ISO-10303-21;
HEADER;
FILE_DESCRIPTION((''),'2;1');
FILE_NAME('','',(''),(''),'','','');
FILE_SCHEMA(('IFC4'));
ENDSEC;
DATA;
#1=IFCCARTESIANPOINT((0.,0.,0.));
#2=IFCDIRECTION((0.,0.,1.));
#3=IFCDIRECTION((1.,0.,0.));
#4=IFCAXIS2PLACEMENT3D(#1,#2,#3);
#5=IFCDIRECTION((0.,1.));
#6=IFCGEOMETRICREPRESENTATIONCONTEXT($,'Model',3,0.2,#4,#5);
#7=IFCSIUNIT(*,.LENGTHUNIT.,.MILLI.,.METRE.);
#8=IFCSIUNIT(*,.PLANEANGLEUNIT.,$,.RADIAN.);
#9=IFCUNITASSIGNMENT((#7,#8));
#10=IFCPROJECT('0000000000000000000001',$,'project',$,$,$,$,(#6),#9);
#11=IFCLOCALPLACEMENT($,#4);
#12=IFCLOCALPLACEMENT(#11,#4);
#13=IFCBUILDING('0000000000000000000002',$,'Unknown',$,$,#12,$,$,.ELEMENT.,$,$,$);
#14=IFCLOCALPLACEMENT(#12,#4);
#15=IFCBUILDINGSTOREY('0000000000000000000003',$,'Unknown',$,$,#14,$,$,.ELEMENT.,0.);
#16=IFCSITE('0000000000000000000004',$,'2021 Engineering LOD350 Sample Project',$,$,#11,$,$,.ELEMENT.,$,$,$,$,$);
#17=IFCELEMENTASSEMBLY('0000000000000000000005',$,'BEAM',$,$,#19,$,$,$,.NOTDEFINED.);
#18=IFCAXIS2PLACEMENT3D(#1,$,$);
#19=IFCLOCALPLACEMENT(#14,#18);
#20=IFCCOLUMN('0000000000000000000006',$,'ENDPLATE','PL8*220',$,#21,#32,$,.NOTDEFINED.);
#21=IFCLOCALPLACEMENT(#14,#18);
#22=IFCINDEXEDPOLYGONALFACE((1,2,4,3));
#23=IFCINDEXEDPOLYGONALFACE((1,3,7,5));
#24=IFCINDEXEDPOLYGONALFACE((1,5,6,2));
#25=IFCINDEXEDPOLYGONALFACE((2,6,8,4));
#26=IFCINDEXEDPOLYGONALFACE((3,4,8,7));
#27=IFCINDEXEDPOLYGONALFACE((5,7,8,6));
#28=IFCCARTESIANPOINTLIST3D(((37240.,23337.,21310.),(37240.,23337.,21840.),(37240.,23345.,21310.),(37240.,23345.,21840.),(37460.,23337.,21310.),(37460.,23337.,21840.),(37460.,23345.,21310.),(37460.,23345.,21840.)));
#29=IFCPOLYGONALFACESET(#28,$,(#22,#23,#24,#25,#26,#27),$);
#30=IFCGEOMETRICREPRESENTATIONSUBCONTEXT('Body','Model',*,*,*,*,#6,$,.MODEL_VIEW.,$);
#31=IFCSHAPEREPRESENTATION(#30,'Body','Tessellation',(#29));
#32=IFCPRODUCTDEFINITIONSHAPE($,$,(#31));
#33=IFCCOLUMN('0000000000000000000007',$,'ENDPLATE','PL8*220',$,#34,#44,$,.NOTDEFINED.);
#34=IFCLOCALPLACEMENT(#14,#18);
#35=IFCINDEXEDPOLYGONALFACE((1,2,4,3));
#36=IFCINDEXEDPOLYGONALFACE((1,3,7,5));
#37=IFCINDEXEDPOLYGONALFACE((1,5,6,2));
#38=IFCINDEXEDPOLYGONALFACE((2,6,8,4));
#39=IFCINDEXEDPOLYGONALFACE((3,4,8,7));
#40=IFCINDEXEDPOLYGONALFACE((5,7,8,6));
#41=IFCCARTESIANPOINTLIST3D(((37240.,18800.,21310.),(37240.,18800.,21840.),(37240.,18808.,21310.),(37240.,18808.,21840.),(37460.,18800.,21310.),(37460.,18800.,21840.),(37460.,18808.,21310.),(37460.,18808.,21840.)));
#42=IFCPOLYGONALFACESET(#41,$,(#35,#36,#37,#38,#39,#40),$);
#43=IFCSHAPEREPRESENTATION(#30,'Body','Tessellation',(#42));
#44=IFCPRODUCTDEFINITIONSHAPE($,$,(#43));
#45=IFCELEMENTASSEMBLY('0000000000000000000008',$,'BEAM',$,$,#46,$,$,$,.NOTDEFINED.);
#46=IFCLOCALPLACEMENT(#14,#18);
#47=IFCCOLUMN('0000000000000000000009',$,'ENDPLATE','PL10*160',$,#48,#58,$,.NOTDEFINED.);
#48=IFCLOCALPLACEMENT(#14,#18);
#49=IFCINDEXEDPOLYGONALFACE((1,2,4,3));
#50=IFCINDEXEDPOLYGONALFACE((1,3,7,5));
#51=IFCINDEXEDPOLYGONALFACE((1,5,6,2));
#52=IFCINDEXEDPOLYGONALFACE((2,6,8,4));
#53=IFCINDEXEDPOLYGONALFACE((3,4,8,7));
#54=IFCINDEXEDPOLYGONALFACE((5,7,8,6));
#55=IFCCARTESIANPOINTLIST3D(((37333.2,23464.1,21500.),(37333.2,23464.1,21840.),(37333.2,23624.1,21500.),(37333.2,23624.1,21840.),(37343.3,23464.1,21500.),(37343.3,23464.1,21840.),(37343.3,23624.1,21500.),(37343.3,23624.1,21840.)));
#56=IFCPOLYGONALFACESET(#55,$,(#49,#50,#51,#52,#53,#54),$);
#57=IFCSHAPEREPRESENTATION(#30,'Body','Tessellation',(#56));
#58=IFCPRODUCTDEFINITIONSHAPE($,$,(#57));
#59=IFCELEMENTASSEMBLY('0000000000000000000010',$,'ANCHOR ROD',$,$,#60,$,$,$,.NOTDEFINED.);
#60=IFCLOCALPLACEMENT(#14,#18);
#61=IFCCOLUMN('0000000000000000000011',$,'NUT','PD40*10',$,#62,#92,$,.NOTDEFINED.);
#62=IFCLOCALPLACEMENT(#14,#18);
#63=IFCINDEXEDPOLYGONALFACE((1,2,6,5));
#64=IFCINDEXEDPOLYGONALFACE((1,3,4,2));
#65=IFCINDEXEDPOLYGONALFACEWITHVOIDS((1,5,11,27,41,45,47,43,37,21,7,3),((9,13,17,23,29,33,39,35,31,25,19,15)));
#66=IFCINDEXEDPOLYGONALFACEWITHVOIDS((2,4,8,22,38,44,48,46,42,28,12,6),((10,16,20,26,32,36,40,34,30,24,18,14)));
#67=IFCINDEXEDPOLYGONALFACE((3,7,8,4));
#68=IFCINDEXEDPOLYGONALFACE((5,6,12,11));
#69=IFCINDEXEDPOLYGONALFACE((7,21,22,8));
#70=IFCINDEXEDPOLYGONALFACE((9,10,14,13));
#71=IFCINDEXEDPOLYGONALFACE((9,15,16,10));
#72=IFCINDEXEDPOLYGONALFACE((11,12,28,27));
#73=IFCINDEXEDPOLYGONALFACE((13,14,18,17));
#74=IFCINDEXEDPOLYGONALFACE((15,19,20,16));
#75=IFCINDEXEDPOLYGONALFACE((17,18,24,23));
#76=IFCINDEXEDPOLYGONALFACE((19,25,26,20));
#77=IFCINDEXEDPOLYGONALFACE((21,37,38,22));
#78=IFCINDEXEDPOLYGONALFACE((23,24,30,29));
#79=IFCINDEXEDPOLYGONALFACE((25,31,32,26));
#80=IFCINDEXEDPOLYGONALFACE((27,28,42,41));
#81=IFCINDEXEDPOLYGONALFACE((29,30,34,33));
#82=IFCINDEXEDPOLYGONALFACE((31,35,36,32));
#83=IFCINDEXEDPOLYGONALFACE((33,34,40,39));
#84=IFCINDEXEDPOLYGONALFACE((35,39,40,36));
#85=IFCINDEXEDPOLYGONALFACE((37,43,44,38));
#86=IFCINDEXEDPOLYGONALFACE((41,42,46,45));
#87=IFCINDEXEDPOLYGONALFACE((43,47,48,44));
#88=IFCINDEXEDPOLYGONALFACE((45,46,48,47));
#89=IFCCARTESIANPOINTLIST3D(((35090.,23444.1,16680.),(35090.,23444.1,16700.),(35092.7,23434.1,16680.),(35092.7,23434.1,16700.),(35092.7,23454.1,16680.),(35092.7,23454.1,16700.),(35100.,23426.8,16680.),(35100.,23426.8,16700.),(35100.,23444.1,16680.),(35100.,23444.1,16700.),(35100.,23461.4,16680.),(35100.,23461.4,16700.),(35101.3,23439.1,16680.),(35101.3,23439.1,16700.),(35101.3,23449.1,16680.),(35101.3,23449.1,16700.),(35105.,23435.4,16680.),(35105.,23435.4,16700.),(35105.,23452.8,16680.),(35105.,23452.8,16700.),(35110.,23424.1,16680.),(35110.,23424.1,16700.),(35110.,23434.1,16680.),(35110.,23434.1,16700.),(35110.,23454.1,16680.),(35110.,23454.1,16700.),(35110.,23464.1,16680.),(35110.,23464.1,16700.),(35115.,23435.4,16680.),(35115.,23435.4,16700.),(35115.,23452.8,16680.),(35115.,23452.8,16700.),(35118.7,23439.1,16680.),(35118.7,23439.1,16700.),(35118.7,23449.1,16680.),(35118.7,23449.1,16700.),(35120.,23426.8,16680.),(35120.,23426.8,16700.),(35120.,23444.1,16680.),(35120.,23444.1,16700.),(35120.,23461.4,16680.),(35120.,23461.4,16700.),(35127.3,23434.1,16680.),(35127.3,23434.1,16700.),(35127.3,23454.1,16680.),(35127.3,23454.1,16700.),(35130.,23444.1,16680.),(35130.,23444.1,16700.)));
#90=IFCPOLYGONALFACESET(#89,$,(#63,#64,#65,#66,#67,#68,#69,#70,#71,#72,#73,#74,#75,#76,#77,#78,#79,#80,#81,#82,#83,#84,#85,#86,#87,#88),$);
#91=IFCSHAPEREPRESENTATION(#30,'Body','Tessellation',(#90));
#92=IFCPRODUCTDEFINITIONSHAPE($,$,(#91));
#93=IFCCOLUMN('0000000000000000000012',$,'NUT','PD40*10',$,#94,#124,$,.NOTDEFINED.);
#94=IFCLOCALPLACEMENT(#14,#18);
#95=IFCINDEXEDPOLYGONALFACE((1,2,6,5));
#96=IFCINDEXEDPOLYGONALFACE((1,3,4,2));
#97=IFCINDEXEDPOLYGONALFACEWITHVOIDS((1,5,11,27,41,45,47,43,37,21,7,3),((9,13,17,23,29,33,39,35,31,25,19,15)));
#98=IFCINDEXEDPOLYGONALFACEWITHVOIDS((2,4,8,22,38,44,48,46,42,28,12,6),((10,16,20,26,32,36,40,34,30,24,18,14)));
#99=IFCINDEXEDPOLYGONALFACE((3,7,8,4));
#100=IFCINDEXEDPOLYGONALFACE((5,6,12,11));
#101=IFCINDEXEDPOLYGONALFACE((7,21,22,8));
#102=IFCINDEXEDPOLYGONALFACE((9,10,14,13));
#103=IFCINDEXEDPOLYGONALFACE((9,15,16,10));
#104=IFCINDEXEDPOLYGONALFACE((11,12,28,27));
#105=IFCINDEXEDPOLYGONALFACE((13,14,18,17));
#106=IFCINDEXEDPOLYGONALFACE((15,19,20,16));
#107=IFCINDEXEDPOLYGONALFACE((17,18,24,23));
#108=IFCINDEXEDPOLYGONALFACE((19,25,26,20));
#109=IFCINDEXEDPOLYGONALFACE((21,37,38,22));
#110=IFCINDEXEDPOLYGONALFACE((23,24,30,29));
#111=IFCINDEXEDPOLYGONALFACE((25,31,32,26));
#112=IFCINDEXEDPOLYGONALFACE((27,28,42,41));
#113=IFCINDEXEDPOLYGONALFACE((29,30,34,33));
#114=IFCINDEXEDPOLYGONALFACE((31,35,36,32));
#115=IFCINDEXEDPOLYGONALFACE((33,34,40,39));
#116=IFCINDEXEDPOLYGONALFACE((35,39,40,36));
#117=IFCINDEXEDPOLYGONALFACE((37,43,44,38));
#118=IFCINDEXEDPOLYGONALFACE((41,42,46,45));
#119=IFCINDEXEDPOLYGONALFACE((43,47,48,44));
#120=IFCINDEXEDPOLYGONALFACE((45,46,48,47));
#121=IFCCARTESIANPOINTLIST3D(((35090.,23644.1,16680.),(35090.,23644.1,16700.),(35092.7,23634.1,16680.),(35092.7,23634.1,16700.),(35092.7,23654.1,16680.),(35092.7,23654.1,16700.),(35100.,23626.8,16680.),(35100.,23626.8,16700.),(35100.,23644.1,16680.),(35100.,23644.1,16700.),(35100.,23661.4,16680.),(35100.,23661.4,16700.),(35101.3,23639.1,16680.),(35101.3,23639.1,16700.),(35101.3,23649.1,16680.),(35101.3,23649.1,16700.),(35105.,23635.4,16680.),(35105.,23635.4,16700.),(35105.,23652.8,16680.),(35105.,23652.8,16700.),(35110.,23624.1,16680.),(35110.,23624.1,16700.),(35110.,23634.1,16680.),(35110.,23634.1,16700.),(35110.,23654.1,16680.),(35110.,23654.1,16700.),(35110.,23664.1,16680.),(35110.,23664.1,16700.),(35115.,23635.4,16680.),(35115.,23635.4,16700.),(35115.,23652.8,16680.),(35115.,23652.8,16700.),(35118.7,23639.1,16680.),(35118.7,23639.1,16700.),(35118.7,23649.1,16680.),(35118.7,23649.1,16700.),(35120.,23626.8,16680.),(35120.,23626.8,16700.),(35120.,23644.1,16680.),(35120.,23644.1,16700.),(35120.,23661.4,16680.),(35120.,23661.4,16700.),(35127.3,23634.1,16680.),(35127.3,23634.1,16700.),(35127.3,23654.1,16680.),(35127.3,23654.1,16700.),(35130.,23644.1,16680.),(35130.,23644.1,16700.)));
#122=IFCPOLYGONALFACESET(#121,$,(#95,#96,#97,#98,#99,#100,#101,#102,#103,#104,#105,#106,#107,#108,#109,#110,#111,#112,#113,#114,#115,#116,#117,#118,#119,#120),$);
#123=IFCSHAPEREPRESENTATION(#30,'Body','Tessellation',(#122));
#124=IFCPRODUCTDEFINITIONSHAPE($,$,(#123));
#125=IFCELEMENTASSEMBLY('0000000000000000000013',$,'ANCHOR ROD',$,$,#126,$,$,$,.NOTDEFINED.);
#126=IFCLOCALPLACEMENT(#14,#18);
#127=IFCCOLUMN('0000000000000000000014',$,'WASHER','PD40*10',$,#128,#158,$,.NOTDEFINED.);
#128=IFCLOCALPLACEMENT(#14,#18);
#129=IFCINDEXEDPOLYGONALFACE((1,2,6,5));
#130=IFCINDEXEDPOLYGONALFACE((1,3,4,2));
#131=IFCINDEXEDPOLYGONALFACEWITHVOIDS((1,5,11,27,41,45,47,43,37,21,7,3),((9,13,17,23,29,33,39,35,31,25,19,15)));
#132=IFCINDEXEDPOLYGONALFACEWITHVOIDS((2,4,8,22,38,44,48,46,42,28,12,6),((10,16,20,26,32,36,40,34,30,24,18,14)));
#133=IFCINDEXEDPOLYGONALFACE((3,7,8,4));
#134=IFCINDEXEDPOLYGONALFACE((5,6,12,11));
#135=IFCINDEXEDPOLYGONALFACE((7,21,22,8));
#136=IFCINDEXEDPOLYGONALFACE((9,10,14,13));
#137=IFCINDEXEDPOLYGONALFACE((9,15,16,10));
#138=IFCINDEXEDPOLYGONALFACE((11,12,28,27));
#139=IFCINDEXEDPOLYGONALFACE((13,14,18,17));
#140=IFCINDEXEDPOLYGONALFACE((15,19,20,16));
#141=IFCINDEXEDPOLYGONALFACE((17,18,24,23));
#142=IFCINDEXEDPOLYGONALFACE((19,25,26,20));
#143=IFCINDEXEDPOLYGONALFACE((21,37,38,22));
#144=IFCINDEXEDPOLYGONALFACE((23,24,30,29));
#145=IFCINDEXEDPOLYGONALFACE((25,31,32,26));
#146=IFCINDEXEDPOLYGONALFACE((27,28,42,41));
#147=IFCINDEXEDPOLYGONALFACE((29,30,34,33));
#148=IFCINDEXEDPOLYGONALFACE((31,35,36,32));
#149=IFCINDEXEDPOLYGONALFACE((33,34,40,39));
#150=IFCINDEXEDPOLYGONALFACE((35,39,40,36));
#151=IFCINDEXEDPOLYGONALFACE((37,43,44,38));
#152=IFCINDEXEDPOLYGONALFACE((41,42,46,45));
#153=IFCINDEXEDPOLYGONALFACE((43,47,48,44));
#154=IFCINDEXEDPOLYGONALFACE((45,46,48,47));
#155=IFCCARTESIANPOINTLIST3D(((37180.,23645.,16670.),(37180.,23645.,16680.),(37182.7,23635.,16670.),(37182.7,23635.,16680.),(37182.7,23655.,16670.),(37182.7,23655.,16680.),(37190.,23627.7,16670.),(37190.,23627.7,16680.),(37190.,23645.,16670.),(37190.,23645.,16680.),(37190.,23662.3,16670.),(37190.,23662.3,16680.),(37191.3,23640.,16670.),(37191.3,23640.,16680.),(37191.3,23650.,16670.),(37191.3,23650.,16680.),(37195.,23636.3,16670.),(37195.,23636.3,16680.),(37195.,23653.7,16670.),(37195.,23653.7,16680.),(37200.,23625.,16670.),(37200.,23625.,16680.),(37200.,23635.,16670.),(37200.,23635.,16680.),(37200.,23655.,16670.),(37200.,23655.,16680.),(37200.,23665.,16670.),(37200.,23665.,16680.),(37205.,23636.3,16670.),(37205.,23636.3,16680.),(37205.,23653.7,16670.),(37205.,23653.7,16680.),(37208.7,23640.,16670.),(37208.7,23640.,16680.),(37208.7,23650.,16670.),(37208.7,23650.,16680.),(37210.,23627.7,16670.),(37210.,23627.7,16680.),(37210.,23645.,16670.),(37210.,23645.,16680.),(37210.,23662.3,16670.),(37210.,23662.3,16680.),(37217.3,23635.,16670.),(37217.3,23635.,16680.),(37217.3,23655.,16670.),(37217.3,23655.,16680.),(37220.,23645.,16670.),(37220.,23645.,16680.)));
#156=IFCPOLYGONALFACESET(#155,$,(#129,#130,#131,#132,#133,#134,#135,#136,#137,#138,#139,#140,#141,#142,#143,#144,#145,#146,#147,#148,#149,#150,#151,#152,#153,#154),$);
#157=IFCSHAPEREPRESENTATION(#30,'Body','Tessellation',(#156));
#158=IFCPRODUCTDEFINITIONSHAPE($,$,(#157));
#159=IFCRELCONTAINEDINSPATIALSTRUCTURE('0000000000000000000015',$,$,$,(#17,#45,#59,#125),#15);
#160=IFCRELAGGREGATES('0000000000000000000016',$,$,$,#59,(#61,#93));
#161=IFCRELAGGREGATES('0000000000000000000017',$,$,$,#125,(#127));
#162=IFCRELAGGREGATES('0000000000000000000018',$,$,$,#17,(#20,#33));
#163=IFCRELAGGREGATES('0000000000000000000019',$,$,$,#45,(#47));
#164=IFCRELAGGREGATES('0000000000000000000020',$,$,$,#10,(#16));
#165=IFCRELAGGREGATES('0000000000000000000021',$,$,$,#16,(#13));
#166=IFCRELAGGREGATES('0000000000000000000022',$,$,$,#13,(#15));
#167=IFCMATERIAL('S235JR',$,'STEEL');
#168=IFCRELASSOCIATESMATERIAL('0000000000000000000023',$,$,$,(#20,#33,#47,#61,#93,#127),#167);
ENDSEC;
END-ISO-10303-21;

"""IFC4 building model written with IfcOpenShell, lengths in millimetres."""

from ifc_helpers import new_model, si_unit, direction, frame, origin_with_axes, place, context, subcontext, project, spatial, line, indexed_curve, outline, extrude, material, element, aggregate, save


model = new_model("IFC4")

# Units and contexts
model_context = context("Model", 3, precision=0.2, world=origin_with_axes(), true_north=direction((0.0, 1.0)))
body_context = subcontext(model_context, "Body", "Model", "MODEL_VIEW")
ifc_project = project(units=[si_unit("LENGTHUNIT", "METRE", prefix="MILLI"), si_unit("PLANEANGLEUNIT", "RADIAN")], contexts=[model_context])

# Site, building, storey
site_placement = place(None, origin_with_axes())
site = spatial("IfcSite", under=ifc_project, at=site_placement, Name="2021 Engineering LOD350 Sample Project", CompositionType="ELEMENT")
building_placement = place(site_placement, origin_with_axes())
building = spatial("IfcBuilding", under=site, at=building_placement, Name="Unknown", CompositionType="ELEMENT")
storey_placement = place(building_placement, origin_with_axes())
storey = spatial("IfcBuildingStorey", under=building, at=storey_placement, Name="Unknown", CompositionType="ELEMENT", Elevation=0.0)

# Shared definitions
ifc_material_1 = material(Name="S235JR", Category="STEEL")

# Element assembly, columns
assembly_1_placement = place(storey_placement, frame((37350.0, 18600.0, 21575.0), z_axis=(1.0, 0.0, 0.0), x_axis=(0.0, 1.0, 0.0)))
assembly_1 = element("IfcElementAssembly", 1, at=assembly_1_placement, inside=storey, Name="BEAM", PredefinedType="NOTDEFINED")
column_1_placement = place(assembly_1_placement, frame((4741.0, -265.0, 0.0), z_axis=(-1.0, 0.0, 0.0), x_axis=(0.0, 1.0, 0.0)))
column_1 = element("IfcColumn", 2, at=column_1_placement, material=ifc_material_1, Name="ENDPLATE", Description="PL8*220", PredefinedType="NOTDEFINED", context=body_context, shape_type="SolidModel", body=[
    extrude(outline(indexed_curve([(-4.0, -110.0), (4.0, -110.0), (4.0, 110.0), (-4.0, 110.0)], segments=[line(1, 2, 3, 4, 1)])), frame((0.0, 0.0, 0.0), z_axis=(-1.0, 0.0, 0.0), x_axis=(0.0, 0.0, 1.0)), (0.0, 0.0, -1.0), 530.0),
])
column_2_placement = place(assembly_1_placement, frame((204.0, -265.0, 0.0), z_axis=(1.0, 0.0, 0.0), x_axis=(0.0, 1.0, 0.0)))
column_2 = element("IfcColumn", 3, at=column_2_placement, material=ifc_material_1, Name="ENDPLATE", Description="PL8*220", PredefinedType="NOTDEFINED", context=body_context, shape_type="SolidModel", body=[
    extrude(outline(indexed_curve([(-4.0, -110.0), (4.0, -110.0), (4.0, 110.0), (-4.0, 110.0)], segments=[line(1, 2, 3, 4, 1)])), frame((0.0, 0.0, 0.0), z_axis=(-1.0, 0.0, 0.0), x_axis=(0.0, 0.0, 1.0)), (0.0, 0.0, -1.0), 530.0),
])

# Element assembly, column
assembly_2_placement = place(storey_placement, frame((34920.0, 23544.1, 21670.0), z_axis=(0.0, -1.0, 0.0), x_axis=(1.0, 0.0, 0.0)))
assembly_2 = element("IfcElementAssembly", 4, at=assembly_2_placement, inside=storey, Name="BEAM", PredefinedType="NOTDEFINED")
column_3_placement = place(assembly_2_placement, frame((2418.2, -170.0, 0.0), z_axis=(1.0, 0.0, 0.0), x_axis=(0.0, 1.0, 0.0)))
column_3 = element("IfcColumn", 5, at=column_3_placement, material=ifc_material_1, Name="ENDPLATE", Description="PL10*160", PredefinedType="NOTDEFINED", context=body_context, shape_type="SolidModel", body=[
    extrude(outline(indexed_curve([(-5.0, -80.0), (5.0, -80.0), (5.0, 80.0), (-5.0, 80.0)], segments=[line(1, 2, 3, 4, 1)])), frame((0.0, 0.0, 0.0), z_axis=(-1.0, 0.0, 0.0), x_axis=(0.0, 0.0, 1.0)), (0.0, 0.0, -1.0), 340.0),
])

# Element assemblies, columns
assembly_3_placement = place(storey_placement, frame((35110.0, 23644.1, 16710.0), z_axis=(1.0, 0.0, 0.0), x_axis=(0.0, 0.0, -1.0)))
assembly_3 = element("IfcElementAssembly", 6, at=assembly_3_placement, inside=storey, Name="ANCHOR ROD", PredefinedType="NOTDEFINED")
column_4_placement = place(assembly_3_placement, frame((10.0, -200.0, 0.0), z_axis=(0.0, 0.0, 1.0), x_axis=(1.0, 0.0, 0.0)))
column_4 = element("IfcColumn", 7, at=column_4_placement, material=ifc_material_1, Name="NUT", Description="PD40*10", PredefinedType="NOTDEFINED", context=body_context, shape_type="SolidModel", body=[
    extrude(outline(indexed_curve([(20.0, 0.0), (17.3, 10.0), (10.0, 17.3), (0.0, 20.0), (-10.0, 17.3), (-17.3, 10.0), (-20.0, 0.0), (-17.3, -10.0), (-10.0, -17.3), (0.0, -20.0), (10.0, -17.3), (17.3, -10.0)], segments=[line(1, 2, 3, 4, 5, 6, 7, 8, 9, 10, 11, 12, 1)]), holes=[indexed_curve([(10.0, 0.0), (8.7, -5.0), (5.0, -8.7), (0.0, -10.0), (-5.0, -8.7), (-8.7, -5.0), (-10.0, 0.0), (-8.7, 5.0), (-5.0, 8.7), (0.0, 10.0), (5.0, 8.7), (8.7, 5.0)], segments=[line(1, 2, 3, 4, 5, 6, 7, 8, 9, 10, 11, 12, 1)])]), frame((0.0, 0.0, 0.0), z_axis=(-1.0, 0.0, 0.0), x_axis=(0.0, 0.0, 1.0)), (0.0, 0.0, -1.0), 20.0),
])
column_5_placement = place(assembly_3_placement, frame((10.0, 0.0, 0.0), z_axis=(0.0, 0.0, 1.0), x_axis=(1.0, 0.0, 0.0)))
column_5 = element("IfcColumn", 8, at=column_5_placement, material=ifc_material_1, Name="NUT", Description="PD40*10", PredefinedType="NOTDEFINED", context=body_context, shape_type="SolidModel", body=[
    extrude(outline(indexed_curve([(20.0, 0.0), (17.3, 10.0), (10.0, 17.3), (0.0, 20.0), (-10.0, 17.3), (-17.3, 10.0), (-20.0, 0.0), (-17.3, -10.0), (-10.0, -17.3), (0.0, -20.0), (10.0, -17.3), (17.3, -10.0)], segments=[line(1, 2, 3, 4, 5, 6, 7, 8, 9, 10, 11, 12, 1)]), holes=[indexed_curve([(10.0, 0.0), (8.7, -5.0), (5.0, -8.7), (0.0, -10.0), (-5.0, -8.7), (-8.7, -5.0), (-10.0, 0.0), (-8.7, 5.0), (-5.0, 8.7), (0.0, 10.0), (5.0, 8.7), (8.7, 5.0)], segments=[line(1, 2, 3, 4, 5, 6, 7, 8, 9, 10, 11, 12, 1)])]), frame((0.0, 0.0, 0.0), z_axis=(-1.0, 0.0, 0.0), x_axis=(0.0, 0.0, 1.0)), (0.0, 0.0, -1.0), 20.0),
])
aggregate(assembly_3, [column_4, column_5])
assembly_4_placement = place(storey_placement, frame((37500.0, 23645.0, 16710.0), z_axis=(1.0, 0.0, 0.0), x_axis=(0.0, 0.0, -1.0)))
assembly_4 = element("IfcElementAssembly", 9, at=assembly_4_placement, inside=storey, Name="ANCHOR ROD", PredefinedType="NOTDEFINED")
column_6_placement = place(assembly_4_placement, frame((30.0, 0.0, -300.0), z_axis=(0.0, 0.0, -1.0), x_axis=(1.0, 0.0, 0.0)))
column_6 = element("IfcColumn", 10, at=column_6_placement, material=ifc_material_1, Name="WASHER", Description="PD40*10", PredefinedType="NOTDEFINED", context=body_context, shape_type="SolidModel", body=[
    extrude(outline(indexed_curve([(20.0, 0.0), (17.3, 10.0), (10.0, 17.3), (0.0, 20.0), (-10.0, 17.3), (-17.3, 10.0), (-20.0, 0.0), (-17.3, -10.0), (-10.0, -17.3), (0.0, -20.0), (10.0, -17.3), (17.3, -10.0)], segments=[line(1, 2, 3, 4, 5, 6, 7, 8, 9, 10, 11, 12, 1)]), holes=[indexed_curve([(10.0, 0.0), (8.7, -5.0), (5.0, -8.7), (0.0, -10.0), (-5.0, -8.7), (-8.7, -5.0), (-10.0, 0.0), (-8.7, 5.0), (-5.0, 8.7), (0.0, 10.0), (5.0, 8.7), (8.7, 5.0)], segments=[line(1, 2, 3, 4, 5, 6, 7, 8, 9, 10, 11, 12, 1)])]), frame((0.0, 0.0, 0.0), z_axis=(-1.0, 0.0, 0.0), x_axis=(0.0, 0.0, 1.0)), (0.0, 0.0, -1.0), 10.0),
])
aggregate(assembly_4, [column_6])

aggregate(assembly_1, [column_1, column_2])
aggregate(assembly_2, [column_3])

save(model, "model.ifc")
